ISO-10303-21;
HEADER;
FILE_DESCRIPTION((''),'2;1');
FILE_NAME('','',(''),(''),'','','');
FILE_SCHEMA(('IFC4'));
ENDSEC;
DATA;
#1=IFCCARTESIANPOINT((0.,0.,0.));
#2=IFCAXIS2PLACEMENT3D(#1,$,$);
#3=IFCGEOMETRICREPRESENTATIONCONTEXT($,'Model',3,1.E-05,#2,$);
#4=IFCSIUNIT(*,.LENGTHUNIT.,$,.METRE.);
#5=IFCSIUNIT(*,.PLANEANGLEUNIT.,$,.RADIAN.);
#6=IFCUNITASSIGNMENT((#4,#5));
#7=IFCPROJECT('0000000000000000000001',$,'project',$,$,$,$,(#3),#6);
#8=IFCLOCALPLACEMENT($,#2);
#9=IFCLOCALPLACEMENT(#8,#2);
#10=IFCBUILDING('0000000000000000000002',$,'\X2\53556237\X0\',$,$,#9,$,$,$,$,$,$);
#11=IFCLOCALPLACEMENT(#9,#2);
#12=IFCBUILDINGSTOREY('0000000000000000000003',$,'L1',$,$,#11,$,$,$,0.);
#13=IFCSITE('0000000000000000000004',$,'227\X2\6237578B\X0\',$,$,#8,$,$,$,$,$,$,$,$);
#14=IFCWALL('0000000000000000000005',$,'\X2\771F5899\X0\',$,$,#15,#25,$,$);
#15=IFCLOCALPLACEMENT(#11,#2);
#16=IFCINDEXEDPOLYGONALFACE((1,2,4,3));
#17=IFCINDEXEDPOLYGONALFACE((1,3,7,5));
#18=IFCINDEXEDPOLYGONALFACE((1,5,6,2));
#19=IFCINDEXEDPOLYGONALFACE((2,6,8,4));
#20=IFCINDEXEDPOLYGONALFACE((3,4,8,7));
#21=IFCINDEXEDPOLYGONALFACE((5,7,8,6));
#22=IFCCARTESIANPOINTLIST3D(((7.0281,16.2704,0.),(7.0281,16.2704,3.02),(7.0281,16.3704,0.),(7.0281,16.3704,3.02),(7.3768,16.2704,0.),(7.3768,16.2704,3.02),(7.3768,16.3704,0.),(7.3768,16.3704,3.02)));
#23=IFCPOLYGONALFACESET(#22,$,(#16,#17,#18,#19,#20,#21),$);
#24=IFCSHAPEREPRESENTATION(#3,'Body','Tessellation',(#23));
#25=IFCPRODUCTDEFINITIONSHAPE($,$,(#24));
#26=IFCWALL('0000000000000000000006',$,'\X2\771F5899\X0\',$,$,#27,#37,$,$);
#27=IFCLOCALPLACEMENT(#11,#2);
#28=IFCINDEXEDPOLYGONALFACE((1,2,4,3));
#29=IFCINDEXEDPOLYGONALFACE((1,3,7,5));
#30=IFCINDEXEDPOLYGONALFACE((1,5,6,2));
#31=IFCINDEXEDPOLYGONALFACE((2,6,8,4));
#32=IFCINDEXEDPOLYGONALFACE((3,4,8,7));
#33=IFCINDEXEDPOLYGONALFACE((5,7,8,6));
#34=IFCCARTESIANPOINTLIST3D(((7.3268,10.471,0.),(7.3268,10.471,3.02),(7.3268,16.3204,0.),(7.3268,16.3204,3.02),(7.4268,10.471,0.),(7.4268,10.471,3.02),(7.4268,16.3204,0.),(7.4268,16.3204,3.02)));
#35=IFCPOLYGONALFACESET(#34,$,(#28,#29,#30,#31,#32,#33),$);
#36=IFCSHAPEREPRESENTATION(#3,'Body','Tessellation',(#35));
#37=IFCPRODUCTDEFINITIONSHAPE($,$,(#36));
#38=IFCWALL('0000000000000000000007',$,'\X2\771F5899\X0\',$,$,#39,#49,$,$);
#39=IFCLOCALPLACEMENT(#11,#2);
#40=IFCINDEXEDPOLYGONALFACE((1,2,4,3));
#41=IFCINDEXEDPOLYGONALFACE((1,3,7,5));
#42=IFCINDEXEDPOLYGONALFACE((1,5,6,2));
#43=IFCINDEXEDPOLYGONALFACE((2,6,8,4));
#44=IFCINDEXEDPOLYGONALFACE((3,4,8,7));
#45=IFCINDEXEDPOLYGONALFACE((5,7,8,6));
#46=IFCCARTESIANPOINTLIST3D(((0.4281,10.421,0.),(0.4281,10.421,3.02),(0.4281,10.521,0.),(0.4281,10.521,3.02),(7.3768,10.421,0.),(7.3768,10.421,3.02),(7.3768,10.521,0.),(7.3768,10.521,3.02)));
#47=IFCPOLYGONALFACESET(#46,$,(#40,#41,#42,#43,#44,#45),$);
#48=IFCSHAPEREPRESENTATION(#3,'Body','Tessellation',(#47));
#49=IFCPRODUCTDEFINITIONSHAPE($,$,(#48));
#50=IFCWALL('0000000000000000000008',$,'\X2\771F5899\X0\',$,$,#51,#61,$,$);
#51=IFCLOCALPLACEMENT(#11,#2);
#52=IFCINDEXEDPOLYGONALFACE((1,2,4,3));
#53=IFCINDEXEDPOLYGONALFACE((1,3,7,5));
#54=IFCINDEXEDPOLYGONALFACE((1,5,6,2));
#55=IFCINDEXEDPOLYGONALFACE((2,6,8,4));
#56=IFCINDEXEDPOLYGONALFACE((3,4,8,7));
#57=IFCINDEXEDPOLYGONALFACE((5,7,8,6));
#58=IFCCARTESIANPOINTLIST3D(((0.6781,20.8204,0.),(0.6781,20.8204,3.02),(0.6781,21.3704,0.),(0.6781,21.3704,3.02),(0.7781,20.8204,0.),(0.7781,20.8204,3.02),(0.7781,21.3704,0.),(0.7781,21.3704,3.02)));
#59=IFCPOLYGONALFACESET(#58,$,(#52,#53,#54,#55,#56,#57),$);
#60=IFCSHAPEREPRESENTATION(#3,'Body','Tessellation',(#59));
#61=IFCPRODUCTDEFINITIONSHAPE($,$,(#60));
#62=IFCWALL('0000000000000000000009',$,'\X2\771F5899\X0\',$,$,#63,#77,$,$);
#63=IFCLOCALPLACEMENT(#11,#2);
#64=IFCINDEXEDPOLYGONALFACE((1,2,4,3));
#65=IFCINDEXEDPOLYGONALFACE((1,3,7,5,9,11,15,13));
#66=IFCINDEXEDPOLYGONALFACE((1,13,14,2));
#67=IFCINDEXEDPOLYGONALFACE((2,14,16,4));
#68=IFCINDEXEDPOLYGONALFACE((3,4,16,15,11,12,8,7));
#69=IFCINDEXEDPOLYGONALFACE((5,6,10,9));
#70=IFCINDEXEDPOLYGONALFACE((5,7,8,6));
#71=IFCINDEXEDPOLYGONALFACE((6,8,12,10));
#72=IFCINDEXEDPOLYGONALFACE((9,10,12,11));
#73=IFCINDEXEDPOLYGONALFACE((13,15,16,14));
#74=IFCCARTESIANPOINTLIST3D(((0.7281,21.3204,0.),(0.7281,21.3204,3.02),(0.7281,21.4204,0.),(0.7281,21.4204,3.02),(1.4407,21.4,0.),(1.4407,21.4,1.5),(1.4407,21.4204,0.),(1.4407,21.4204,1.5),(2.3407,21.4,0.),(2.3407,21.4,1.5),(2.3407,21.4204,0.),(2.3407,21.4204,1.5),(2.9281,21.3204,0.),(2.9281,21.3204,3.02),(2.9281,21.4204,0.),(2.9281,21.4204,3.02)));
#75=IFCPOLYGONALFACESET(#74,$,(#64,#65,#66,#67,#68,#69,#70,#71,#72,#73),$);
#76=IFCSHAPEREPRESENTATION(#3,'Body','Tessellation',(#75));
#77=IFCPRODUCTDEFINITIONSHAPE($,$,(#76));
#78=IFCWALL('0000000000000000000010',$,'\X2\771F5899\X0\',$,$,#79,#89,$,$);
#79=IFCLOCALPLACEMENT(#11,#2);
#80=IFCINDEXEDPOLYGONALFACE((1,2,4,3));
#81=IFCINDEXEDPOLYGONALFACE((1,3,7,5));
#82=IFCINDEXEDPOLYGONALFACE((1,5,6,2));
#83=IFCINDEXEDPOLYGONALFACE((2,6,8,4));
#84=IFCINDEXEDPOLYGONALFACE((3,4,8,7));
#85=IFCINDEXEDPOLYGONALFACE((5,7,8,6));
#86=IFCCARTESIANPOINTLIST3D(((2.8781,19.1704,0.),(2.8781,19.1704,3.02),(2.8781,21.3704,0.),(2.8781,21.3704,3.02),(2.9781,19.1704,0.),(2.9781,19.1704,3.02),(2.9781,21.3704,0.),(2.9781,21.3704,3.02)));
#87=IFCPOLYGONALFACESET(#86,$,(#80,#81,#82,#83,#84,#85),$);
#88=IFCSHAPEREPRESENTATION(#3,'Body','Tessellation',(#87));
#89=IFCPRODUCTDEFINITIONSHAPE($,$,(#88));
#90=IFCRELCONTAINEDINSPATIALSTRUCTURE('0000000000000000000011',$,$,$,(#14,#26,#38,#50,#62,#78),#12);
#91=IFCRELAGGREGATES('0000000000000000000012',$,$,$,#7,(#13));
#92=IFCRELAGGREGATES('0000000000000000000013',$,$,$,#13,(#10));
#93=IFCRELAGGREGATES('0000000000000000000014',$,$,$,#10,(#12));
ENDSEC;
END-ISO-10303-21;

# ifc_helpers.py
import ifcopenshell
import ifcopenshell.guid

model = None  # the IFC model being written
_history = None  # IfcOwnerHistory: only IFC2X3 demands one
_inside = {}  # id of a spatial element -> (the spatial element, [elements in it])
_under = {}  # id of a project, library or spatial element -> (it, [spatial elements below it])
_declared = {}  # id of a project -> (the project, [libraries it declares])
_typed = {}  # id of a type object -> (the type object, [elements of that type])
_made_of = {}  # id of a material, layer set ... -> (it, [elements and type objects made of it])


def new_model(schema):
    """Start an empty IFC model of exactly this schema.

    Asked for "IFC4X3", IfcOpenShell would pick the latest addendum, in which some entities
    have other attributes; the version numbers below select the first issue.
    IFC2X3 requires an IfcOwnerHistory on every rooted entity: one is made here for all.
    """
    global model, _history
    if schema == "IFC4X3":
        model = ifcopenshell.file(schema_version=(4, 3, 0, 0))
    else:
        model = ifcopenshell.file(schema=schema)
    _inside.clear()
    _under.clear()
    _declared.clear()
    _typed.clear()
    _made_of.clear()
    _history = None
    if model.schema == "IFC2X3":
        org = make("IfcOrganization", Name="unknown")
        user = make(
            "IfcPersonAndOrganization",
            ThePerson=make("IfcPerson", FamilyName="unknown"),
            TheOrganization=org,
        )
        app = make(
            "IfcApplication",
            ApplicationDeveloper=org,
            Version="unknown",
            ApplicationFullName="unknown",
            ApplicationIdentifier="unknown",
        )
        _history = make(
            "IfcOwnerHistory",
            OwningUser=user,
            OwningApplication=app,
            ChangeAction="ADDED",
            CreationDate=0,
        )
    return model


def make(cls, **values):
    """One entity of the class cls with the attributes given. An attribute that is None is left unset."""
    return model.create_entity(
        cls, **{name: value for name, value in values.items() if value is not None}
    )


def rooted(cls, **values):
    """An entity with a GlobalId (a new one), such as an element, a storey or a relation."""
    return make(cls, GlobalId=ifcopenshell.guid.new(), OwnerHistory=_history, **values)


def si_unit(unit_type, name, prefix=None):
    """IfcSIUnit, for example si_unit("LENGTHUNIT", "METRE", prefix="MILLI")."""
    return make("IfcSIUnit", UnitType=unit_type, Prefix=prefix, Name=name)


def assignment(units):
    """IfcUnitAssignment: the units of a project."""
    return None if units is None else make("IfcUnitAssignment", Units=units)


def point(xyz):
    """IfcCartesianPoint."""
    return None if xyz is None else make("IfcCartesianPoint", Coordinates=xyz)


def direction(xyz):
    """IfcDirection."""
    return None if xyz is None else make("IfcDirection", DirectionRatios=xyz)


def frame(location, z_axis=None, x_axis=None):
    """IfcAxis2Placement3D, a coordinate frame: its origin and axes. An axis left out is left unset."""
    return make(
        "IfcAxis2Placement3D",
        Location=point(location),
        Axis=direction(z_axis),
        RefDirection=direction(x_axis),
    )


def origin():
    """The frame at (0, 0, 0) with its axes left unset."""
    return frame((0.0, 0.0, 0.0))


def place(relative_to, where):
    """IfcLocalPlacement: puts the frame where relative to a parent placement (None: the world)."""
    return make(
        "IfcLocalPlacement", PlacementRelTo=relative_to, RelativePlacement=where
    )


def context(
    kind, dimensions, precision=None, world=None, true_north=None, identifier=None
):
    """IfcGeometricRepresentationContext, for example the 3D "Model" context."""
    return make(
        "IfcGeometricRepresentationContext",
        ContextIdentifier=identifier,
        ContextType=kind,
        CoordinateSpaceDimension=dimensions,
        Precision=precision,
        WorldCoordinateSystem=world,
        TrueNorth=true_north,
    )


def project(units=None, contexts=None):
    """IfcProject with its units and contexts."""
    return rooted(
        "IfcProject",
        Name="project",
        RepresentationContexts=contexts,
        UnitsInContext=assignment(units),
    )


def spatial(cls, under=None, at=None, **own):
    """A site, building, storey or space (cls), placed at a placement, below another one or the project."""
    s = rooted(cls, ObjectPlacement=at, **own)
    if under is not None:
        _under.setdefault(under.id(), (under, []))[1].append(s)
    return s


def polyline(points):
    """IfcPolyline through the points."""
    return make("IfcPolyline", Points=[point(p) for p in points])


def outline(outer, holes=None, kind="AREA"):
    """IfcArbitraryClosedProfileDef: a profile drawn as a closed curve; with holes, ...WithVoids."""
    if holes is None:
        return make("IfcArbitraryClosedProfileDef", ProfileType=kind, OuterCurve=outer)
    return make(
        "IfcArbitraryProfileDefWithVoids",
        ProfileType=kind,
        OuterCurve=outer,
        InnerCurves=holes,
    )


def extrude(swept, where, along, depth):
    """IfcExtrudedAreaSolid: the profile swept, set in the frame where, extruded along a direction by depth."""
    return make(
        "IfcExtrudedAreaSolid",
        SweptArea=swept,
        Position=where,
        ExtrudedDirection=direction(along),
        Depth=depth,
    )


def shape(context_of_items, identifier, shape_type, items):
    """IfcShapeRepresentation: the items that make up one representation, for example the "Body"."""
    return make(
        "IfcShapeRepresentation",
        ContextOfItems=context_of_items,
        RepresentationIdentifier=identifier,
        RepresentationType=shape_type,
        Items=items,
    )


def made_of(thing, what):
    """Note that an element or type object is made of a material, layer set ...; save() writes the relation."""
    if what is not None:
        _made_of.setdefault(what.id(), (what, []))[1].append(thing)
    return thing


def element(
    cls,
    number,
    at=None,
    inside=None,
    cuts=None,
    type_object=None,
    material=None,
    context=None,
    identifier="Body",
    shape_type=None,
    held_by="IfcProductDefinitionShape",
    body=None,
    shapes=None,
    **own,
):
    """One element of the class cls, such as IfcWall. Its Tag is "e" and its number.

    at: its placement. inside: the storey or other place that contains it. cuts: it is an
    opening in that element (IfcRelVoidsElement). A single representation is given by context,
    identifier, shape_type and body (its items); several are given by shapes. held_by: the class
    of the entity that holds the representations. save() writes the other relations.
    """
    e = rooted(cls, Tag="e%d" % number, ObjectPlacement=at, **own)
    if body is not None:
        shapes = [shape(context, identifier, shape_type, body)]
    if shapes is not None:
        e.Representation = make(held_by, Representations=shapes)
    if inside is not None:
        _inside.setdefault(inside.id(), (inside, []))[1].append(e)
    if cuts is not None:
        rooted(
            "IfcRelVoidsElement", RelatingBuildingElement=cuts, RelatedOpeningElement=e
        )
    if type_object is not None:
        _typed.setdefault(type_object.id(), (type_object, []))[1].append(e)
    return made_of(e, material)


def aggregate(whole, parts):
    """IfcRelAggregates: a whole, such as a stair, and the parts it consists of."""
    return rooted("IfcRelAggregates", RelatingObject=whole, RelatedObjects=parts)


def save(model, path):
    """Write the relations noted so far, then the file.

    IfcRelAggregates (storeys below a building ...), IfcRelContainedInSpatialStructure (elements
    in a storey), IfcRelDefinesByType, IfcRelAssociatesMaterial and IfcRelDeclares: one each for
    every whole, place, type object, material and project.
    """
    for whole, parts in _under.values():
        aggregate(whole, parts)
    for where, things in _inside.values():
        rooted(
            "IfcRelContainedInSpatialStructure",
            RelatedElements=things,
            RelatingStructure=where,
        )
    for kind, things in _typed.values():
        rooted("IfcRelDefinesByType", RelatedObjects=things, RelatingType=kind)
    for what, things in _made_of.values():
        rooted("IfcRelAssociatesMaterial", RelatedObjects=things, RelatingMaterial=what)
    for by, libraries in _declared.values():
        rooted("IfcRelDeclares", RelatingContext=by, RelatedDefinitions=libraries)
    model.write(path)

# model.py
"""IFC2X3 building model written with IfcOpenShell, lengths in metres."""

from ifc_helpers import new_model, si_unit, origin, place, context, project, spatial, polyline, outline, extrude, element, save


model = new_model("IFC2X3")

# Units and contexts
model_context = context("Model", 3, precision=1e-05, world=origin())
ifc_project = project(units=[si_unit("LENGTHUNIT", "METRE"), si_unit("PLANEANGLEUNIT", "RADIAN")], contexts=[model_context])

# Site, building, storey
site_placement = place(None, origin())
site = spatial("IfcSite", under=ifc_project, at=site_placement, Name="227户型")
building_placement = place(site_placement, origin())
building = spatial("IfcBuilding", under=site, at=building_placement, Name="单户")
storey_placement = place(building_placement, origin())
storey = spatial("IfcBuildingStorey", under=building, at=storey_placement, Name="L1", Elevation=0.0)

# Walls
wall_1_placement = place(storey_placement, origin())
element("IfcWall", 1, at=wall_1_placement, inside=storey, Name="真墙", context=model_context, shape_type="SweptSolid", body=[
    extrude(outline(polyline([(7.0281, 16.3704), (7.3768, 16.3704), (7.3768, 16.2704), (7.0281, 16.2704), (7.0281, 16.3704)])), origin(), (0.0, 0.0, 1.0), 3.02),
])
wall_2_placement = place(storey_placement, origin())
element("IfcWall", 2, at=wall_2_placement, inside=storey, Name="真墙", context=model_context, shape_type="SweptSolid", body=[
    extrude(outline(polyline([(7.4268, 16.3204), (7.4268, 10.471), (7.3268, 10.471), (7.3268, 16.3204), (7.4268, 16.3204)])), origin(), (0.0, 0.0, 1.0), 3.02),
])
wall_3_placement = place(storey_placement, origin())
element("IfcWall", 3, at=wall_3_placement, inside=storey, Name="真墙", context=model_context, shape_type="SweptSolid", body=[
    extrude(outline(polyline([(7.3768, 10.421), (0.4281, 10.421), (0.4281, 10.521), (7.3768, 10.521), (7.3768, 10.421)])), origin(), (0.0, 0.0, 1.0), 3.02),
])
wall_4_placement = place(storey_placement, origin())
element("IfcWall", 4, at=wall_4_placement, inside=storey, Name="真墙", context=model_context, shape_type="SweptSolid", body=[
    extrude(outline(polyline([(0.6781, 20.8204), (0.6781, 21.3704), (0.7781, 21.3704), (0.7781, 20.8204), (0.6781, 20.8204)])), origin(), (0.0, 0.0, 1.0), 3.02),
])

# Wall, opening
wall_5_placement = place(storey_placement, origin())
wall_5 = element("IfcWall", 5, at=wall_5_placement, inside=storey, Name="真墙", context=model_context, shape_type="SweptSolid", body=[
    extrude(outline(polyline([(0.7281, 21.4204), (2.9281, 21.4204), (2.9281, 21.3204), (0.7281, 21.3204), (0.7281, 21.4204)])), origin(), (0.0, 0.0, 1.0), 3.02),
])
opening_1_placement = place(storey_placement, origin())
element("IfcOpeningElement", 6, at=opening_1_placement, cuts=wall_5, context=model_context, shape_type="SweptSolid", body=[
    extrude(outline(polyline([(1.4407, 21.6), (2.3407, 21.6), (2.3407, 21.4), (1.4407, 21.4), (1.4407, 21.6)])), origin(), (0.0, 0.0, 1.0), 1.5),
])

# Wall
wall_6_placement = place(storey_placement, origin())
element("IfcWall", 7, at=wall_6_placement, inside=storey, Name="真墙", context=model_context, shape_type="SweptSolid", body=[
    extrude(outline(polyline([(2.9781, 21.3704), (2.9781, 19.1704), (2.8781, 19.1704), (2.8781, 21.3704), (2.9781, 21.3704)])), origin(), (0.0, 0.0, 1.0), 3.02),
])

save(model, "model.ifc")
